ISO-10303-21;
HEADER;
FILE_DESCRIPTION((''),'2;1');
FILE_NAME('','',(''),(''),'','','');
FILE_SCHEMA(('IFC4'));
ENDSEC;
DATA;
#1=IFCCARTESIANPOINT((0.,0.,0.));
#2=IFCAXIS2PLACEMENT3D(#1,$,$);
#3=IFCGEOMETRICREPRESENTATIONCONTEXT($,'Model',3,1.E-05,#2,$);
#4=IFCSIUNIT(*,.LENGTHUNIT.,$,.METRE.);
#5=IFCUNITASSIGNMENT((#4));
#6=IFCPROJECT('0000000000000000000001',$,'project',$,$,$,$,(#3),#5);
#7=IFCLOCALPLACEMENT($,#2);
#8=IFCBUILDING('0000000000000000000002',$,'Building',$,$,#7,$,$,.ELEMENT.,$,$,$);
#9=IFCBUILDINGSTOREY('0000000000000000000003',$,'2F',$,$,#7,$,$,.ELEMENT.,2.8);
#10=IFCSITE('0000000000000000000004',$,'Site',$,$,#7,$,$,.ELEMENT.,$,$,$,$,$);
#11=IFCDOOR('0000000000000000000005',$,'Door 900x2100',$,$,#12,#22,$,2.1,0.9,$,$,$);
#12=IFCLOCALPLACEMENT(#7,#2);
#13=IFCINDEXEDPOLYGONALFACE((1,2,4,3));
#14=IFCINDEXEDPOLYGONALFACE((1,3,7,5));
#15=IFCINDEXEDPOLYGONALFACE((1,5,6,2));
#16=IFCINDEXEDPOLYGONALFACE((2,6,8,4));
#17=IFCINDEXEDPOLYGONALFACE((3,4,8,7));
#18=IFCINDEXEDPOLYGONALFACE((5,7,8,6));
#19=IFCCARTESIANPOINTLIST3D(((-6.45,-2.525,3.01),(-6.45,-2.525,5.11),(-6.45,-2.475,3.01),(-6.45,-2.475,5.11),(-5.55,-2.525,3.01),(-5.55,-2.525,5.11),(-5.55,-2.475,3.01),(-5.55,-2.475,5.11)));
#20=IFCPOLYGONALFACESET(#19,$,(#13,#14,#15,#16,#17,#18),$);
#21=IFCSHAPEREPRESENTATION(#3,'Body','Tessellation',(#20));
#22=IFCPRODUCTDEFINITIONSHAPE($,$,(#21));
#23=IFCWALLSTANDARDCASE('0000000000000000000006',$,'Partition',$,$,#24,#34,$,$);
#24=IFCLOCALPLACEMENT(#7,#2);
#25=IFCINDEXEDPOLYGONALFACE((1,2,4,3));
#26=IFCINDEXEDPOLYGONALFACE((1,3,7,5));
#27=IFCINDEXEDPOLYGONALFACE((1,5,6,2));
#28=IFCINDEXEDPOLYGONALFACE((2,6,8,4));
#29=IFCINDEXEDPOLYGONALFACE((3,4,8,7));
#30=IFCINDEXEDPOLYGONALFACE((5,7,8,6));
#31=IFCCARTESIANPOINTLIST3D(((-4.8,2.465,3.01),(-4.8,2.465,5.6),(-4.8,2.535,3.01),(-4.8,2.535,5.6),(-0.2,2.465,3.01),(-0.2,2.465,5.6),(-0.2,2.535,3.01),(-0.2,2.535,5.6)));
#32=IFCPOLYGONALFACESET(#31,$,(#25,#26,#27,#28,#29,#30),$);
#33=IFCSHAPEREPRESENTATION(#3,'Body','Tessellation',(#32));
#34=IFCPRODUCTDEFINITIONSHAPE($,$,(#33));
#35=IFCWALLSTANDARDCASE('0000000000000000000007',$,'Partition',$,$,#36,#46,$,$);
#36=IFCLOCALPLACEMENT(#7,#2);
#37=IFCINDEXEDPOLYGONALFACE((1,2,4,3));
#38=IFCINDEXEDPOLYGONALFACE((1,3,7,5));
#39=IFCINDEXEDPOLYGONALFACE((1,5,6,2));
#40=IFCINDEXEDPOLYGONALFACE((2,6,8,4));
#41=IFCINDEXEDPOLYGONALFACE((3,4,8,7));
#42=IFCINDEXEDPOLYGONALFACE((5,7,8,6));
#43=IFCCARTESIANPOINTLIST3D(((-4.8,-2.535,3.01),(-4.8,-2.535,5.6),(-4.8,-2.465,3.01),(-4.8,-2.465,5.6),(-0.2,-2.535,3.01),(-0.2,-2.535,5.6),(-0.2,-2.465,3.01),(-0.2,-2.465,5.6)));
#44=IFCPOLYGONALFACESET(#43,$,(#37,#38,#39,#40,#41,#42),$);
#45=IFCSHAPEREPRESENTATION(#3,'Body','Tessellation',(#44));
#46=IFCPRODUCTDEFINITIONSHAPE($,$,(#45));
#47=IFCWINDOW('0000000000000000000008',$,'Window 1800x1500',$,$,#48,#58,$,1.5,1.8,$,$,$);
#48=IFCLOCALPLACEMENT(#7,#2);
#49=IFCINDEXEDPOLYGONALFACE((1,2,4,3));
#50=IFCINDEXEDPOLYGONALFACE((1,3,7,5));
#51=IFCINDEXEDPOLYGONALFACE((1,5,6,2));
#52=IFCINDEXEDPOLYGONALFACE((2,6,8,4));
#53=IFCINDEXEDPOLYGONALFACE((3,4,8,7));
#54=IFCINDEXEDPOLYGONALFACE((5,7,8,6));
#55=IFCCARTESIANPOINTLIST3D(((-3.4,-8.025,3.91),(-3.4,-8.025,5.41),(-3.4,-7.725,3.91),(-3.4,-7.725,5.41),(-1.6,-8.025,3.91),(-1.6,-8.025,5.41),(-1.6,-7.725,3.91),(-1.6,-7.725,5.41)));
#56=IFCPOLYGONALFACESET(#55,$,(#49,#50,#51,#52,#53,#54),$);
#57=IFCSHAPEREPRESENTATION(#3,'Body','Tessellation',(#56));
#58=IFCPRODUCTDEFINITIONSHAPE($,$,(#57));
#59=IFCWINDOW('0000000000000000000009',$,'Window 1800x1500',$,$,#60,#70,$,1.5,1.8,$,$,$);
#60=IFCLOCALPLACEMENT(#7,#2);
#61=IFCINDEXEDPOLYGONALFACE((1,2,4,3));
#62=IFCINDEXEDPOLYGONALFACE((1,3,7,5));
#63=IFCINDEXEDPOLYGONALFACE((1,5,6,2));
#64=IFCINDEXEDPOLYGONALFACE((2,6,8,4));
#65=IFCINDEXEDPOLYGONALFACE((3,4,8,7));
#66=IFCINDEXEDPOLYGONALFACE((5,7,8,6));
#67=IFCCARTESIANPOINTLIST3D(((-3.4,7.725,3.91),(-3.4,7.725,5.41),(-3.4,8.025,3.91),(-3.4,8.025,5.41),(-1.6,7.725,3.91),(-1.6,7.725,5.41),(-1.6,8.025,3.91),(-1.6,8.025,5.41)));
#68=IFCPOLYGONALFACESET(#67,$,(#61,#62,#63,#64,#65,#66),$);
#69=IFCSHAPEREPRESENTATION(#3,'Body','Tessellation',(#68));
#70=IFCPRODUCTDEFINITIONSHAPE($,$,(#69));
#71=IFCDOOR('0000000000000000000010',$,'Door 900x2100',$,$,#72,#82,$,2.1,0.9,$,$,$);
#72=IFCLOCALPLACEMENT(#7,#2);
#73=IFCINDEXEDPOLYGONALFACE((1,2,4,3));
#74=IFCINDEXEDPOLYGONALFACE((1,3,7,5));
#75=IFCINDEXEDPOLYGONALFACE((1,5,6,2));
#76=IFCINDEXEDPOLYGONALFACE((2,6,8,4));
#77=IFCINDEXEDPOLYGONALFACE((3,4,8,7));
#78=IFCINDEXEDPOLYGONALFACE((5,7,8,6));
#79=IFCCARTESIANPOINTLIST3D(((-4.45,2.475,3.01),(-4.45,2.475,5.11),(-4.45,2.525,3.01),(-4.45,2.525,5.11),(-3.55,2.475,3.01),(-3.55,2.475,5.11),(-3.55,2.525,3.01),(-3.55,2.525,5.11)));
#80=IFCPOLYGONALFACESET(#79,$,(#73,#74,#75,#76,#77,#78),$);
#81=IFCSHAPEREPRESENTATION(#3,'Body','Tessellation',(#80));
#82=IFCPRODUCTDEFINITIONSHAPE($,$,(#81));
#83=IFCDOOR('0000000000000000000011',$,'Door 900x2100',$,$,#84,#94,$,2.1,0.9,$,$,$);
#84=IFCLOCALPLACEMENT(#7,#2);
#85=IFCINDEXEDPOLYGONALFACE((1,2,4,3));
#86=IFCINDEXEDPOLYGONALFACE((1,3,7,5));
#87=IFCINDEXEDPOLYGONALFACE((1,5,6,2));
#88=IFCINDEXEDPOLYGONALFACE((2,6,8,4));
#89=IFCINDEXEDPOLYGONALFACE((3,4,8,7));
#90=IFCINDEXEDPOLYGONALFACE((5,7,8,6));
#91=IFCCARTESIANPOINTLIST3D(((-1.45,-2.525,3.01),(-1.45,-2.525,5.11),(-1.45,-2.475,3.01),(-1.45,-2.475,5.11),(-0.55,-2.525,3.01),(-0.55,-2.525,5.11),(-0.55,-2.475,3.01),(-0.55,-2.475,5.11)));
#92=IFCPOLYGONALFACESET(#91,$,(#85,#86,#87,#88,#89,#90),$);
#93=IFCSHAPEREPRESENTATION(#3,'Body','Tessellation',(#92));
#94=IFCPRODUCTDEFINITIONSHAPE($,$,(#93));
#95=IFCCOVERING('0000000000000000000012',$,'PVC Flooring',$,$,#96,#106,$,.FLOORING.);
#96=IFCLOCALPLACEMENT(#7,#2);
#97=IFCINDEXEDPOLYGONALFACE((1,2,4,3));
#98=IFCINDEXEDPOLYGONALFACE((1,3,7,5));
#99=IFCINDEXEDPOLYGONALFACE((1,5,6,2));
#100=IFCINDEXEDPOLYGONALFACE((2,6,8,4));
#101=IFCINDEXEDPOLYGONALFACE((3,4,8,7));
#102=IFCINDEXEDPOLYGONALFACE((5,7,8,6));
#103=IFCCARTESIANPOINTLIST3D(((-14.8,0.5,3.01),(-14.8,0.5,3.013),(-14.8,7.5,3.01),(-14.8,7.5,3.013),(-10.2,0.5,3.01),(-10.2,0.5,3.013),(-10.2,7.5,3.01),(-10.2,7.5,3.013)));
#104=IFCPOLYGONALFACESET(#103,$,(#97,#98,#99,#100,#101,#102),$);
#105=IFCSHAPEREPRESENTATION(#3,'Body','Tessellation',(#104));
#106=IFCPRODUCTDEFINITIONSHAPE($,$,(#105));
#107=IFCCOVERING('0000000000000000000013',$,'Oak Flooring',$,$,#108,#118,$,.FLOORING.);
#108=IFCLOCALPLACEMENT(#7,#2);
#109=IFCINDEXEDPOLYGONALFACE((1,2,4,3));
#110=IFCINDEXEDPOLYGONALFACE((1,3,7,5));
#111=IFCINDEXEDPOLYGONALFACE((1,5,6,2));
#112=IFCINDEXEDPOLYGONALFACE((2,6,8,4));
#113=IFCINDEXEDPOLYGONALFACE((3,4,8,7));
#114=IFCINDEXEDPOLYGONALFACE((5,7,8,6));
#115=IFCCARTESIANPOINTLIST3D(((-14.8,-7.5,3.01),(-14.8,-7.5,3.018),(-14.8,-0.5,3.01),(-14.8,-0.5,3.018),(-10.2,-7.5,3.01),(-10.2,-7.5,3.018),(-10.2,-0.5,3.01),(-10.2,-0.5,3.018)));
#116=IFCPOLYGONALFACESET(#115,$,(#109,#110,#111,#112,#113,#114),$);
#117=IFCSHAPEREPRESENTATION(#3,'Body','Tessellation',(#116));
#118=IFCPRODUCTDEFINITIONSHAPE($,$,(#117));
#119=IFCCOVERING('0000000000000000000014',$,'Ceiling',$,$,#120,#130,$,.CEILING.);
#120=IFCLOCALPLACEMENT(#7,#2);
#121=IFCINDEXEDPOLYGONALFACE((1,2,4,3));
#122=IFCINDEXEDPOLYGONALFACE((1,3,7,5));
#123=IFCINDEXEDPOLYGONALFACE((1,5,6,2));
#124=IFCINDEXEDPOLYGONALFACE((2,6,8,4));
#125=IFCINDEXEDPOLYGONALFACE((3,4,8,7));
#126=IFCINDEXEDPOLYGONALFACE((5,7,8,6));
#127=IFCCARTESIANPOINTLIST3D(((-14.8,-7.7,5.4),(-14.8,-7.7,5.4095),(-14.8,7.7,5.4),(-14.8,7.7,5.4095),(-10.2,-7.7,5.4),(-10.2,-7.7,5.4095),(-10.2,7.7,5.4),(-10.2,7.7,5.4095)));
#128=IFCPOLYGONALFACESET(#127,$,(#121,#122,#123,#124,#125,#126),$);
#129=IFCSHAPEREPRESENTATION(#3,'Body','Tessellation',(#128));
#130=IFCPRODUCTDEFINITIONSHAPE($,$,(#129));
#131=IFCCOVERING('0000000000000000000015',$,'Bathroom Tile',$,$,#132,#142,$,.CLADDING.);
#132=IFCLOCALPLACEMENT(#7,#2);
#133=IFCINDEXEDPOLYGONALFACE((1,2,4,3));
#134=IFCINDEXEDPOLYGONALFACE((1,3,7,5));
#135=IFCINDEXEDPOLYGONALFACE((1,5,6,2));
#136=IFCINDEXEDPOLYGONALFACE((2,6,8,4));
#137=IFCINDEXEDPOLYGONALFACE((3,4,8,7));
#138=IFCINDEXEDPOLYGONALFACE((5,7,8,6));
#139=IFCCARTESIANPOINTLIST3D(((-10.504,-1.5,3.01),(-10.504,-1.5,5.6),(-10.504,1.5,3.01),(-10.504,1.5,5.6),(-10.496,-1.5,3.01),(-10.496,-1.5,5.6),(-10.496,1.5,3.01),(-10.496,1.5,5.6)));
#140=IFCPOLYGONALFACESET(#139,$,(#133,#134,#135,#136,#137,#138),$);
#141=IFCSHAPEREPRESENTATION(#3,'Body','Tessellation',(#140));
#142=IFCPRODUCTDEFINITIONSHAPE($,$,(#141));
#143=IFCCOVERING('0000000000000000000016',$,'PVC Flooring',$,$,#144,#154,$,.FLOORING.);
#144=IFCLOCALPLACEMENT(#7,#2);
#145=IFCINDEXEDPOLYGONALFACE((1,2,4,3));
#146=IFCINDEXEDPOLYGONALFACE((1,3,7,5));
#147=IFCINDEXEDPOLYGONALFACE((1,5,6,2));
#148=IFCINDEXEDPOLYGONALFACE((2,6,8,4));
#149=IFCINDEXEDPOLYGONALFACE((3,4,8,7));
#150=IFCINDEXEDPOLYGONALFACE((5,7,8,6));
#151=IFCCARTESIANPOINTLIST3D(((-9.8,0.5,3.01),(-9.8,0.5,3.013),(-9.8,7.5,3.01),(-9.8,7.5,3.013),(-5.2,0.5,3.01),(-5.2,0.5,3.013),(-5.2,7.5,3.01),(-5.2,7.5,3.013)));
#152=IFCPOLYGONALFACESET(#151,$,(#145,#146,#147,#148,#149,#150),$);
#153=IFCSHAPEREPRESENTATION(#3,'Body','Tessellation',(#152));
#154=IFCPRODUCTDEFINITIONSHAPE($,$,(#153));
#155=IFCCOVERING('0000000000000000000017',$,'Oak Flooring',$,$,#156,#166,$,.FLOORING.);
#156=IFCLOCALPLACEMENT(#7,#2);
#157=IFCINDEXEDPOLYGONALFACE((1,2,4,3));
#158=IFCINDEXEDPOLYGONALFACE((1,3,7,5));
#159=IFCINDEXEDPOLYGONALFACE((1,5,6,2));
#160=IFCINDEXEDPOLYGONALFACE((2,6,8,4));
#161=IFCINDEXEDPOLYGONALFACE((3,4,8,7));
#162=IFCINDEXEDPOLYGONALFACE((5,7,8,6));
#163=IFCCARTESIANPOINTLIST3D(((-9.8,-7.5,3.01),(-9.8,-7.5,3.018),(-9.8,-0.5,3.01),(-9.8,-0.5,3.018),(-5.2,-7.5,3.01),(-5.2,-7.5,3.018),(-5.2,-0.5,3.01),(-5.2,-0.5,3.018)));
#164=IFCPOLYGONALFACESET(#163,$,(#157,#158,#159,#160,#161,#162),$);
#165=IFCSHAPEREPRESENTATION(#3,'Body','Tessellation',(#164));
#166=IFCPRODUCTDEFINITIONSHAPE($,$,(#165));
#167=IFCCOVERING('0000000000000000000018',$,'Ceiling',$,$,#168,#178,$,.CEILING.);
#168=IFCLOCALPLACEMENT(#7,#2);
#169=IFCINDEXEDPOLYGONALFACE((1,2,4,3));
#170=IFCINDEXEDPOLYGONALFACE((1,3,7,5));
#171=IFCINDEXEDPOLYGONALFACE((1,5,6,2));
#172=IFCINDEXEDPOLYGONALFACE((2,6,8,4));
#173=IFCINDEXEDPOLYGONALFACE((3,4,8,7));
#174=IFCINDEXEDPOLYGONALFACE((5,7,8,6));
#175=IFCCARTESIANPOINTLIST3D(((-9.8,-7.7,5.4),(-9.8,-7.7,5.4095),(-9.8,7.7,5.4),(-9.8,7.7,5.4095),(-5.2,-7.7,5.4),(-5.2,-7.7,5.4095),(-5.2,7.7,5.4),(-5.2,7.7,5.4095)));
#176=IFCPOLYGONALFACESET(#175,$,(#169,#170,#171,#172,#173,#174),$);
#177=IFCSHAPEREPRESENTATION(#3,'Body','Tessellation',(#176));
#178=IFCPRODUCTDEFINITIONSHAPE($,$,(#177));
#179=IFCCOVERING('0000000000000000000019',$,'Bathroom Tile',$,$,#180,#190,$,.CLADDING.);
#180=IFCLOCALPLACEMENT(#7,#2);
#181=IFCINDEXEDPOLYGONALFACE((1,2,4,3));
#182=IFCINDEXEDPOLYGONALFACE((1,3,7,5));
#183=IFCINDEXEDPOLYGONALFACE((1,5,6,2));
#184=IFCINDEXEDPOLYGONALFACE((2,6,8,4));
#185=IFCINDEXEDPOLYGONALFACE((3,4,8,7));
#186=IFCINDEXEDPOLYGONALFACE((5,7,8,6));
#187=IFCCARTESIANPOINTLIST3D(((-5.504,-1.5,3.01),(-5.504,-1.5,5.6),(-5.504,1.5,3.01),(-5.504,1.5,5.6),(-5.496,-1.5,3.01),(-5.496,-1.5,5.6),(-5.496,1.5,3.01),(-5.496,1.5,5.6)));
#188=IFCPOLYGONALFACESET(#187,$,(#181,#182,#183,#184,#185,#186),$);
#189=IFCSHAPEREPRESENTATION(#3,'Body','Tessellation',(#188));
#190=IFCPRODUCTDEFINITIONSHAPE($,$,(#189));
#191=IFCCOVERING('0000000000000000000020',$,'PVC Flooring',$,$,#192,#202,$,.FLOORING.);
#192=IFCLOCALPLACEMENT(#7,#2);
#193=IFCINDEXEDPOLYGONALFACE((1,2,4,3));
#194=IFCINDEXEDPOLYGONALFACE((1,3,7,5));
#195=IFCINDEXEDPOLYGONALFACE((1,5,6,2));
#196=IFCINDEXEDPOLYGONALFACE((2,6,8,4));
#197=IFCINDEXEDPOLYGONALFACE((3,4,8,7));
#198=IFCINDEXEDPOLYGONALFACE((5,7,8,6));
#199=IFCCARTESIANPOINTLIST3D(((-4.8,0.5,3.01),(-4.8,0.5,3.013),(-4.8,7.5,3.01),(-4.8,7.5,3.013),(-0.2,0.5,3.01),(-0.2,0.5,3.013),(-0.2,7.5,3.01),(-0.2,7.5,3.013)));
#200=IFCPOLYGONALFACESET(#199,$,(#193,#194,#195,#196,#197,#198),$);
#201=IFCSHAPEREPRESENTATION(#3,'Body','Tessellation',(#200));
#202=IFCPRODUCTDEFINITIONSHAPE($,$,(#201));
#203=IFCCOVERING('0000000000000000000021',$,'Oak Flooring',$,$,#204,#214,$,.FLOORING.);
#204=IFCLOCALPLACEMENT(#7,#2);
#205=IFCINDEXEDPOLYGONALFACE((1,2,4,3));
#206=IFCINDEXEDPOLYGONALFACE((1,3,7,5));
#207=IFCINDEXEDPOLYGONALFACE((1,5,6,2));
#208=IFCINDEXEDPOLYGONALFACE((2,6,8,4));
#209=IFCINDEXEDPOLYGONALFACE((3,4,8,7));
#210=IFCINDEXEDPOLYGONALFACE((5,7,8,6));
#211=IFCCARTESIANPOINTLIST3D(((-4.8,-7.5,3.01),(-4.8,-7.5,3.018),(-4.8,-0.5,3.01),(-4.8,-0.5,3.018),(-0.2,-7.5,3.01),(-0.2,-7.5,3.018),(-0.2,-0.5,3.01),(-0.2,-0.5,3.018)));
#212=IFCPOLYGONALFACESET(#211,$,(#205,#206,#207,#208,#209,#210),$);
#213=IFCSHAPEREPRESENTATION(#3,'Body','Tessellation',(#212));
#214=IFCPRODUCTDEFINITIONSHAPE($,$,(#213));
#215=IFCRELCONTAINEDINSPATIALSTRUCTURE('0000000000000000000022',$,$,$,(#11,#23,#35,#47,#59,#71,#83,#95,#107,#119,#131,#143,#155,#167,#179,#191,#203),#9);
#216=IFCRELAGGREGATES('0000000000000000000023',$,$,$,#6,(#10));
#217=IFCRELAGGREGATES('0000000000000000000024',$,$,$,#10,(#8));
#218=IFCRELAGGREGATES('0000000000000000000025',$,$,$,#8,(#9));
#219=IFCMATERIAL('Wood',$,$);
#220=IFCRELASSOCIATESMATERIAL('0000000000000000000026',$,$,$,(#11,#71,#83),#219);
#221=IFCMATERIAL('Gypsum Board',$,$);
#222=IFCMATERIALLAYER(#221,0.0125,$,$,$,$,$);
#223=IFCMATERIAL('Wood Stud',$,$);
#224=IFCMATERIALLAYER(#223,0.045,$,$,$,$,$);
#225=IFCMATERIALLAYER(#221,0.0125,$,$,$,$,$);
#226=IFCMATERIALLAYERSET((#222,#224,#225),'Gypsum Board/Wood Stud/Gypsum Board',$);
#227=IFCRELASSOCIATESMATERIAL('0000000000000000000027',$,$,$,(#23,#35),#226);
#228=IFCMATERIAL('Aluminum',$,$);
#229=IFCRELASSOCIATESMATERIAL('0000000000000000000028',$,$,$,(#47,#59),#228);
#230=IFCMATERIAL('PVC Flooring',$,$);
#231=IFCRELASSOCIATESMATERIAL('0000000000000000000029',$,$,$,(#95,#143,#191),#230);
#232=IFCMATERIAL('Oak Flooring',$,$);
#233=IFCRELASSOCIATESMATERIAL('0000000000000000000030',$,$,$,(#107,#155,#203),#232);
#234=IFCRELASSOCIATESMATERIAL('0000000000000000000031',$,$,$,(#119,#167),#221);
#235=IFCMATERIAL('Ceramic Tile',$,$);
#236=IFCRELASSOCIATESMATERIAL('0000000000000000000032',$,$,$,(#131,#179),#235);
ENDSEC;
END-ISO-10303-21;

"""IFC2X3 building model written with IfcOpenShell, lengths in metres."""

from ifc_helpers import new_model, si_unit, frame, origin, origin_2d, place, context, project, spatial, rectangle, extrude, material, layer, layer_set, layer_usage, element, save


model = new_model("IFC2X3")

# Units and contexts
model_context = context("Model", 3, precision=1e-05, world=origin())
ifc_project = project(units=[si_unit("LENGTHUNIT", "METRE")], contexts=[model_context])

# Site, building, storey
placement = place(None, origin())
site = spatial("IfcSite", under=ifc_project, at=placement, Name="Site", CompositionType="ELEMENT")
building = spatial("IfcBuilding", under=site, at=placement, Name="Building", CompositionType="ELEMENT")
storey = spatial("IfcBuildingStorey", under=building, at=placement, Name="2F", CompositionType="ELEMENT", Elevation=2.8)

# Shared definitions
ifc_material_1 = material(Name="Gypsum Board")
ifc_layer_1 = layer(ifc_material_1, 0.0125)
ifc_material_2 = material(Name="Wood Stud")
ifc_layer_2 = layer(ifc_material_2, 0.045)
ifc_layer_3 = layer(ifc_material_1, 0.0125)
ifc_layer_set_1 = layer_set([ifc_layer_1, ifc_layer_2, ifc_layer_3], Name="Gypsum Board/Wood Stud/Gypsum Board")
ifc_layer_usage_1 = layer_usage(ifc_layer_set_1, "AXIS2", "POSITIVE", 0.0)

# Shared definitions
ifc_material_3 = material(Name="Aluminum")

# Shared definitions
ifc_material_4 = material(Name="Wood")

# Door
for number, where, name in (
    (1, (-6.0, -2.5, 3.01), "Door 900x2100"),
):
    element("IfcDoor", number, at=place(None, frame(where)), inside=storey, material=ifc_material_4, Name=name, OverallHeight=2.1, OverallWidth=0.9, context=model_context, shape_type="SweptSolid", body=[
        extrude(rectangle(XDim=0.9, YDim=0.05, at=origin_2d()), origin(), (0.0, 0.0, 1.0), 2.1),
    ])

# Walls
for number, where, name in (
    (2, (-2.5, 2.5, 3.01), "Partition"),
    (3, (-2.5, -2.5, 3.01), "Partition"),
):
    element("IfcWallStandardCase", number, at=place(None, frame(where)), inside=storey, material=ifc_layer_usage_1, Name=name, context=model_context, shape_type="SweptSolid", body=[
        extrude(rectangle(XDim=4.6, YDim=0.07, at=origin_2d()), origin(), (0.0, 0.0, 1.0), 2.59),
    ])

# Windows
for number, where, name in (
    (4, (-2.5, -7.875, 3.91), "Window 1800x1500"),
    (5, (-2.5, 7.875, 3.91), "Window 1800x1500"),
):
    element("IfcWindow", number, at=place(None, frame(where)), inside=storey, material=ifc_material_3, Name=name, OverallHeight=1.5, OverallWidth=1.8, context=model_context, shape_type="SweptSolid", body=[
        extrude(rectangle(XDim=1.8, YDim=0.3, at=origin_2d()), origin(), (0.0, 0.0, 1.0), 1.5),
    ])

# Doors
for number, where, name in (
    (6, (-4.0, 2.5, 3.01), "Door 900x2100"),
    (7, (-1.0, -2.5, 3.01), "Door 900x2100"),
):
    element("IfcDoor", number, at=place(None, frame(where)), inside=storey, material=ifc_material_4, Name=name, OverallHeight=2.1, OverallWidth=0.9, context=model_context, shape_type="SweptSolid", body=[
        extrude(rectangle(XDim=0.9, YDim=0.05, at=origin_2d()), origin(), (0.0, 0.0, 1.0), 2.1),
    ])

# Coverings
ifc_material_5 = material(Name="PVC Flooring")
covering_1_placement = place(None, frame((-12.5, 4.0, 3.01)))
element("IfcCovering", 8, at=covering_1_placement, inside=storey, material=ifc_material_5, Name="PVC Flooring", PredefinedType="FLOORING", context=model_context, shape_type="SweptSolid", body=[
    extrude(rectangle(XDim=4.6, YDim=7.0, at=origin_2d()), origin(), (0.0, 0.0, 1.0), 0.003),
])
ifc_material_6 = material(Name="Oak Flooring")
covering_2_placement = place(None, frame((-12.5, -4.0, 3.01)))
element("IfcCovering", 9, at=covering_2_placement, inside=storey, material=ifc_material_6, Name="Oak Flooring", PredefinedType="FLOORING", context=model_context, shape_type="SweptSolid", body=[
    extrude(rectangle(XDim=4.6, YDim=7.0, at=origin_2d()), origin(), (0.0, 0.0, 1.0), 0.008),
])
covering_3_placement = place(None, frame((-12.5, 0.0, 5.4)))
element("IfcCovering", 10, at=covering_3_placement, inside=storey, material=ifc_material_1, Name="Ceiling", PredefinedType="CEILING", context=model_context, shape_type="SweptSolid", body=[
    extrude(rectangle(XDim=4.6, YDim=15.4, at=origin_2d()), origin(), (0.0, 0.0, 1.0), 0.0095),
])
ifc_material_7 = material(Name="Ceramic Tile")
covering_4_placement = place(None, frame((-10.5, 0.0, 3.01)))
element("IfcCovering", 11, at=covering_4_placement, inside=storey, material=ifc_material_7, Name="Bathroom Tile", PredefinedType="CLADDING", context=model_context, shape_type="SweptSolid", body=[
    extrude(rectangle(XDim=0.008, YDim=3.0, at=origin_2d()), origin(), (0.0, 0.0, 1.0), 2.59),
])
covering_5_placement = place(None, frame((-7.5, 4.0, 3.01)))
element("IfcCovering", 12, at=covering_5_placement, inside=storey, material=ifc_material_5, Name="PVC Flooring", PredefinedType="FLOORING", context=model_context, shape_type="SweptSolid", body=[
    extrude(rectangle(XDim=4.6, YDim=7.0, at=origin_2d()), origin(), (0.0, 0.0, 1.0), 0.003),
])
covering_6_placement = place(None, frame((-7.5, -4.0, 3.01)))
element("IfcCovering", 13, at=covering_6_placement, inside=storey, material=ifc_material_6, Name="Oak Flooring", PredefinedType="FLOORING", context=model_context, shape_type="SweptSolid", body=[
    extrude(rectangle(XDim=4.6, YDim=7.0, at=origin_2d()), origin(), (0.0, 0.0, 1.0), 0.008),
])
covering_7_placement = place(None, frame((-7.5, 0.0, 5.4)))
element("IfcCovering", 14, at=covering_7_placement, inside=storey, material=ifc_material_1, Name="Ceiling", PredefinedType="CEILING", context=model_context, shape_type="SweptSolid", body=[
    extrude(rectangle(XDim=4.6, YDim=15.4, at=origin_2d()), origin(), (0.0, 0.0, 1.0), 0.0095),
])
covering_8_placement = place(None, frame((-5.5, 0.0, 3.01)))
element("IfcCovering", 15, at=covering_8_placement, inside=storey, material=ifc_material_7, Name="Bathroom Tile", PredefinedType="CLADDING", context=model_context, shape_type="SweptSolid", body=[
    extrude(rectangle(XDim=0.008, YDim=3.0, at=origin_2d()), origin(), (0.0, 0.0, 1.0), 2.59),
])
covering_9_placement = place(None, frame((-2.5, 4.0, 3.01)))
element("IfcCovering", 16, at=covering_9_placement, inside=storey, material=ifc_material_5, Name="PVC Flooring", PredefinedType="FLOORING", context=model_context, shape_type="SweptSolid", body=[
    extrude(rectangle(XDim=4.6, YDim=7.0, at=origin_2d()), origin(), (0.0, 0.0, 1.0), 0.003),
])
covering_10_placement = place(None, frame((-2.5, -4.0, 3.01)))
element("IfcCovering", 17, at=covering_10_placement, inside=storey, material=ifc_material_6, Name="Oak Flooring", PredefinedType="FLOORING", context=model_context, shape_type="SweptSolid", body=[
    extrude(rectangle(XDim=4.6, YDim=7.0, at=origin_2d()), origin(), (0.0, 0.0, 1.0), 0.008),
])

save(model, "model.ifc")
